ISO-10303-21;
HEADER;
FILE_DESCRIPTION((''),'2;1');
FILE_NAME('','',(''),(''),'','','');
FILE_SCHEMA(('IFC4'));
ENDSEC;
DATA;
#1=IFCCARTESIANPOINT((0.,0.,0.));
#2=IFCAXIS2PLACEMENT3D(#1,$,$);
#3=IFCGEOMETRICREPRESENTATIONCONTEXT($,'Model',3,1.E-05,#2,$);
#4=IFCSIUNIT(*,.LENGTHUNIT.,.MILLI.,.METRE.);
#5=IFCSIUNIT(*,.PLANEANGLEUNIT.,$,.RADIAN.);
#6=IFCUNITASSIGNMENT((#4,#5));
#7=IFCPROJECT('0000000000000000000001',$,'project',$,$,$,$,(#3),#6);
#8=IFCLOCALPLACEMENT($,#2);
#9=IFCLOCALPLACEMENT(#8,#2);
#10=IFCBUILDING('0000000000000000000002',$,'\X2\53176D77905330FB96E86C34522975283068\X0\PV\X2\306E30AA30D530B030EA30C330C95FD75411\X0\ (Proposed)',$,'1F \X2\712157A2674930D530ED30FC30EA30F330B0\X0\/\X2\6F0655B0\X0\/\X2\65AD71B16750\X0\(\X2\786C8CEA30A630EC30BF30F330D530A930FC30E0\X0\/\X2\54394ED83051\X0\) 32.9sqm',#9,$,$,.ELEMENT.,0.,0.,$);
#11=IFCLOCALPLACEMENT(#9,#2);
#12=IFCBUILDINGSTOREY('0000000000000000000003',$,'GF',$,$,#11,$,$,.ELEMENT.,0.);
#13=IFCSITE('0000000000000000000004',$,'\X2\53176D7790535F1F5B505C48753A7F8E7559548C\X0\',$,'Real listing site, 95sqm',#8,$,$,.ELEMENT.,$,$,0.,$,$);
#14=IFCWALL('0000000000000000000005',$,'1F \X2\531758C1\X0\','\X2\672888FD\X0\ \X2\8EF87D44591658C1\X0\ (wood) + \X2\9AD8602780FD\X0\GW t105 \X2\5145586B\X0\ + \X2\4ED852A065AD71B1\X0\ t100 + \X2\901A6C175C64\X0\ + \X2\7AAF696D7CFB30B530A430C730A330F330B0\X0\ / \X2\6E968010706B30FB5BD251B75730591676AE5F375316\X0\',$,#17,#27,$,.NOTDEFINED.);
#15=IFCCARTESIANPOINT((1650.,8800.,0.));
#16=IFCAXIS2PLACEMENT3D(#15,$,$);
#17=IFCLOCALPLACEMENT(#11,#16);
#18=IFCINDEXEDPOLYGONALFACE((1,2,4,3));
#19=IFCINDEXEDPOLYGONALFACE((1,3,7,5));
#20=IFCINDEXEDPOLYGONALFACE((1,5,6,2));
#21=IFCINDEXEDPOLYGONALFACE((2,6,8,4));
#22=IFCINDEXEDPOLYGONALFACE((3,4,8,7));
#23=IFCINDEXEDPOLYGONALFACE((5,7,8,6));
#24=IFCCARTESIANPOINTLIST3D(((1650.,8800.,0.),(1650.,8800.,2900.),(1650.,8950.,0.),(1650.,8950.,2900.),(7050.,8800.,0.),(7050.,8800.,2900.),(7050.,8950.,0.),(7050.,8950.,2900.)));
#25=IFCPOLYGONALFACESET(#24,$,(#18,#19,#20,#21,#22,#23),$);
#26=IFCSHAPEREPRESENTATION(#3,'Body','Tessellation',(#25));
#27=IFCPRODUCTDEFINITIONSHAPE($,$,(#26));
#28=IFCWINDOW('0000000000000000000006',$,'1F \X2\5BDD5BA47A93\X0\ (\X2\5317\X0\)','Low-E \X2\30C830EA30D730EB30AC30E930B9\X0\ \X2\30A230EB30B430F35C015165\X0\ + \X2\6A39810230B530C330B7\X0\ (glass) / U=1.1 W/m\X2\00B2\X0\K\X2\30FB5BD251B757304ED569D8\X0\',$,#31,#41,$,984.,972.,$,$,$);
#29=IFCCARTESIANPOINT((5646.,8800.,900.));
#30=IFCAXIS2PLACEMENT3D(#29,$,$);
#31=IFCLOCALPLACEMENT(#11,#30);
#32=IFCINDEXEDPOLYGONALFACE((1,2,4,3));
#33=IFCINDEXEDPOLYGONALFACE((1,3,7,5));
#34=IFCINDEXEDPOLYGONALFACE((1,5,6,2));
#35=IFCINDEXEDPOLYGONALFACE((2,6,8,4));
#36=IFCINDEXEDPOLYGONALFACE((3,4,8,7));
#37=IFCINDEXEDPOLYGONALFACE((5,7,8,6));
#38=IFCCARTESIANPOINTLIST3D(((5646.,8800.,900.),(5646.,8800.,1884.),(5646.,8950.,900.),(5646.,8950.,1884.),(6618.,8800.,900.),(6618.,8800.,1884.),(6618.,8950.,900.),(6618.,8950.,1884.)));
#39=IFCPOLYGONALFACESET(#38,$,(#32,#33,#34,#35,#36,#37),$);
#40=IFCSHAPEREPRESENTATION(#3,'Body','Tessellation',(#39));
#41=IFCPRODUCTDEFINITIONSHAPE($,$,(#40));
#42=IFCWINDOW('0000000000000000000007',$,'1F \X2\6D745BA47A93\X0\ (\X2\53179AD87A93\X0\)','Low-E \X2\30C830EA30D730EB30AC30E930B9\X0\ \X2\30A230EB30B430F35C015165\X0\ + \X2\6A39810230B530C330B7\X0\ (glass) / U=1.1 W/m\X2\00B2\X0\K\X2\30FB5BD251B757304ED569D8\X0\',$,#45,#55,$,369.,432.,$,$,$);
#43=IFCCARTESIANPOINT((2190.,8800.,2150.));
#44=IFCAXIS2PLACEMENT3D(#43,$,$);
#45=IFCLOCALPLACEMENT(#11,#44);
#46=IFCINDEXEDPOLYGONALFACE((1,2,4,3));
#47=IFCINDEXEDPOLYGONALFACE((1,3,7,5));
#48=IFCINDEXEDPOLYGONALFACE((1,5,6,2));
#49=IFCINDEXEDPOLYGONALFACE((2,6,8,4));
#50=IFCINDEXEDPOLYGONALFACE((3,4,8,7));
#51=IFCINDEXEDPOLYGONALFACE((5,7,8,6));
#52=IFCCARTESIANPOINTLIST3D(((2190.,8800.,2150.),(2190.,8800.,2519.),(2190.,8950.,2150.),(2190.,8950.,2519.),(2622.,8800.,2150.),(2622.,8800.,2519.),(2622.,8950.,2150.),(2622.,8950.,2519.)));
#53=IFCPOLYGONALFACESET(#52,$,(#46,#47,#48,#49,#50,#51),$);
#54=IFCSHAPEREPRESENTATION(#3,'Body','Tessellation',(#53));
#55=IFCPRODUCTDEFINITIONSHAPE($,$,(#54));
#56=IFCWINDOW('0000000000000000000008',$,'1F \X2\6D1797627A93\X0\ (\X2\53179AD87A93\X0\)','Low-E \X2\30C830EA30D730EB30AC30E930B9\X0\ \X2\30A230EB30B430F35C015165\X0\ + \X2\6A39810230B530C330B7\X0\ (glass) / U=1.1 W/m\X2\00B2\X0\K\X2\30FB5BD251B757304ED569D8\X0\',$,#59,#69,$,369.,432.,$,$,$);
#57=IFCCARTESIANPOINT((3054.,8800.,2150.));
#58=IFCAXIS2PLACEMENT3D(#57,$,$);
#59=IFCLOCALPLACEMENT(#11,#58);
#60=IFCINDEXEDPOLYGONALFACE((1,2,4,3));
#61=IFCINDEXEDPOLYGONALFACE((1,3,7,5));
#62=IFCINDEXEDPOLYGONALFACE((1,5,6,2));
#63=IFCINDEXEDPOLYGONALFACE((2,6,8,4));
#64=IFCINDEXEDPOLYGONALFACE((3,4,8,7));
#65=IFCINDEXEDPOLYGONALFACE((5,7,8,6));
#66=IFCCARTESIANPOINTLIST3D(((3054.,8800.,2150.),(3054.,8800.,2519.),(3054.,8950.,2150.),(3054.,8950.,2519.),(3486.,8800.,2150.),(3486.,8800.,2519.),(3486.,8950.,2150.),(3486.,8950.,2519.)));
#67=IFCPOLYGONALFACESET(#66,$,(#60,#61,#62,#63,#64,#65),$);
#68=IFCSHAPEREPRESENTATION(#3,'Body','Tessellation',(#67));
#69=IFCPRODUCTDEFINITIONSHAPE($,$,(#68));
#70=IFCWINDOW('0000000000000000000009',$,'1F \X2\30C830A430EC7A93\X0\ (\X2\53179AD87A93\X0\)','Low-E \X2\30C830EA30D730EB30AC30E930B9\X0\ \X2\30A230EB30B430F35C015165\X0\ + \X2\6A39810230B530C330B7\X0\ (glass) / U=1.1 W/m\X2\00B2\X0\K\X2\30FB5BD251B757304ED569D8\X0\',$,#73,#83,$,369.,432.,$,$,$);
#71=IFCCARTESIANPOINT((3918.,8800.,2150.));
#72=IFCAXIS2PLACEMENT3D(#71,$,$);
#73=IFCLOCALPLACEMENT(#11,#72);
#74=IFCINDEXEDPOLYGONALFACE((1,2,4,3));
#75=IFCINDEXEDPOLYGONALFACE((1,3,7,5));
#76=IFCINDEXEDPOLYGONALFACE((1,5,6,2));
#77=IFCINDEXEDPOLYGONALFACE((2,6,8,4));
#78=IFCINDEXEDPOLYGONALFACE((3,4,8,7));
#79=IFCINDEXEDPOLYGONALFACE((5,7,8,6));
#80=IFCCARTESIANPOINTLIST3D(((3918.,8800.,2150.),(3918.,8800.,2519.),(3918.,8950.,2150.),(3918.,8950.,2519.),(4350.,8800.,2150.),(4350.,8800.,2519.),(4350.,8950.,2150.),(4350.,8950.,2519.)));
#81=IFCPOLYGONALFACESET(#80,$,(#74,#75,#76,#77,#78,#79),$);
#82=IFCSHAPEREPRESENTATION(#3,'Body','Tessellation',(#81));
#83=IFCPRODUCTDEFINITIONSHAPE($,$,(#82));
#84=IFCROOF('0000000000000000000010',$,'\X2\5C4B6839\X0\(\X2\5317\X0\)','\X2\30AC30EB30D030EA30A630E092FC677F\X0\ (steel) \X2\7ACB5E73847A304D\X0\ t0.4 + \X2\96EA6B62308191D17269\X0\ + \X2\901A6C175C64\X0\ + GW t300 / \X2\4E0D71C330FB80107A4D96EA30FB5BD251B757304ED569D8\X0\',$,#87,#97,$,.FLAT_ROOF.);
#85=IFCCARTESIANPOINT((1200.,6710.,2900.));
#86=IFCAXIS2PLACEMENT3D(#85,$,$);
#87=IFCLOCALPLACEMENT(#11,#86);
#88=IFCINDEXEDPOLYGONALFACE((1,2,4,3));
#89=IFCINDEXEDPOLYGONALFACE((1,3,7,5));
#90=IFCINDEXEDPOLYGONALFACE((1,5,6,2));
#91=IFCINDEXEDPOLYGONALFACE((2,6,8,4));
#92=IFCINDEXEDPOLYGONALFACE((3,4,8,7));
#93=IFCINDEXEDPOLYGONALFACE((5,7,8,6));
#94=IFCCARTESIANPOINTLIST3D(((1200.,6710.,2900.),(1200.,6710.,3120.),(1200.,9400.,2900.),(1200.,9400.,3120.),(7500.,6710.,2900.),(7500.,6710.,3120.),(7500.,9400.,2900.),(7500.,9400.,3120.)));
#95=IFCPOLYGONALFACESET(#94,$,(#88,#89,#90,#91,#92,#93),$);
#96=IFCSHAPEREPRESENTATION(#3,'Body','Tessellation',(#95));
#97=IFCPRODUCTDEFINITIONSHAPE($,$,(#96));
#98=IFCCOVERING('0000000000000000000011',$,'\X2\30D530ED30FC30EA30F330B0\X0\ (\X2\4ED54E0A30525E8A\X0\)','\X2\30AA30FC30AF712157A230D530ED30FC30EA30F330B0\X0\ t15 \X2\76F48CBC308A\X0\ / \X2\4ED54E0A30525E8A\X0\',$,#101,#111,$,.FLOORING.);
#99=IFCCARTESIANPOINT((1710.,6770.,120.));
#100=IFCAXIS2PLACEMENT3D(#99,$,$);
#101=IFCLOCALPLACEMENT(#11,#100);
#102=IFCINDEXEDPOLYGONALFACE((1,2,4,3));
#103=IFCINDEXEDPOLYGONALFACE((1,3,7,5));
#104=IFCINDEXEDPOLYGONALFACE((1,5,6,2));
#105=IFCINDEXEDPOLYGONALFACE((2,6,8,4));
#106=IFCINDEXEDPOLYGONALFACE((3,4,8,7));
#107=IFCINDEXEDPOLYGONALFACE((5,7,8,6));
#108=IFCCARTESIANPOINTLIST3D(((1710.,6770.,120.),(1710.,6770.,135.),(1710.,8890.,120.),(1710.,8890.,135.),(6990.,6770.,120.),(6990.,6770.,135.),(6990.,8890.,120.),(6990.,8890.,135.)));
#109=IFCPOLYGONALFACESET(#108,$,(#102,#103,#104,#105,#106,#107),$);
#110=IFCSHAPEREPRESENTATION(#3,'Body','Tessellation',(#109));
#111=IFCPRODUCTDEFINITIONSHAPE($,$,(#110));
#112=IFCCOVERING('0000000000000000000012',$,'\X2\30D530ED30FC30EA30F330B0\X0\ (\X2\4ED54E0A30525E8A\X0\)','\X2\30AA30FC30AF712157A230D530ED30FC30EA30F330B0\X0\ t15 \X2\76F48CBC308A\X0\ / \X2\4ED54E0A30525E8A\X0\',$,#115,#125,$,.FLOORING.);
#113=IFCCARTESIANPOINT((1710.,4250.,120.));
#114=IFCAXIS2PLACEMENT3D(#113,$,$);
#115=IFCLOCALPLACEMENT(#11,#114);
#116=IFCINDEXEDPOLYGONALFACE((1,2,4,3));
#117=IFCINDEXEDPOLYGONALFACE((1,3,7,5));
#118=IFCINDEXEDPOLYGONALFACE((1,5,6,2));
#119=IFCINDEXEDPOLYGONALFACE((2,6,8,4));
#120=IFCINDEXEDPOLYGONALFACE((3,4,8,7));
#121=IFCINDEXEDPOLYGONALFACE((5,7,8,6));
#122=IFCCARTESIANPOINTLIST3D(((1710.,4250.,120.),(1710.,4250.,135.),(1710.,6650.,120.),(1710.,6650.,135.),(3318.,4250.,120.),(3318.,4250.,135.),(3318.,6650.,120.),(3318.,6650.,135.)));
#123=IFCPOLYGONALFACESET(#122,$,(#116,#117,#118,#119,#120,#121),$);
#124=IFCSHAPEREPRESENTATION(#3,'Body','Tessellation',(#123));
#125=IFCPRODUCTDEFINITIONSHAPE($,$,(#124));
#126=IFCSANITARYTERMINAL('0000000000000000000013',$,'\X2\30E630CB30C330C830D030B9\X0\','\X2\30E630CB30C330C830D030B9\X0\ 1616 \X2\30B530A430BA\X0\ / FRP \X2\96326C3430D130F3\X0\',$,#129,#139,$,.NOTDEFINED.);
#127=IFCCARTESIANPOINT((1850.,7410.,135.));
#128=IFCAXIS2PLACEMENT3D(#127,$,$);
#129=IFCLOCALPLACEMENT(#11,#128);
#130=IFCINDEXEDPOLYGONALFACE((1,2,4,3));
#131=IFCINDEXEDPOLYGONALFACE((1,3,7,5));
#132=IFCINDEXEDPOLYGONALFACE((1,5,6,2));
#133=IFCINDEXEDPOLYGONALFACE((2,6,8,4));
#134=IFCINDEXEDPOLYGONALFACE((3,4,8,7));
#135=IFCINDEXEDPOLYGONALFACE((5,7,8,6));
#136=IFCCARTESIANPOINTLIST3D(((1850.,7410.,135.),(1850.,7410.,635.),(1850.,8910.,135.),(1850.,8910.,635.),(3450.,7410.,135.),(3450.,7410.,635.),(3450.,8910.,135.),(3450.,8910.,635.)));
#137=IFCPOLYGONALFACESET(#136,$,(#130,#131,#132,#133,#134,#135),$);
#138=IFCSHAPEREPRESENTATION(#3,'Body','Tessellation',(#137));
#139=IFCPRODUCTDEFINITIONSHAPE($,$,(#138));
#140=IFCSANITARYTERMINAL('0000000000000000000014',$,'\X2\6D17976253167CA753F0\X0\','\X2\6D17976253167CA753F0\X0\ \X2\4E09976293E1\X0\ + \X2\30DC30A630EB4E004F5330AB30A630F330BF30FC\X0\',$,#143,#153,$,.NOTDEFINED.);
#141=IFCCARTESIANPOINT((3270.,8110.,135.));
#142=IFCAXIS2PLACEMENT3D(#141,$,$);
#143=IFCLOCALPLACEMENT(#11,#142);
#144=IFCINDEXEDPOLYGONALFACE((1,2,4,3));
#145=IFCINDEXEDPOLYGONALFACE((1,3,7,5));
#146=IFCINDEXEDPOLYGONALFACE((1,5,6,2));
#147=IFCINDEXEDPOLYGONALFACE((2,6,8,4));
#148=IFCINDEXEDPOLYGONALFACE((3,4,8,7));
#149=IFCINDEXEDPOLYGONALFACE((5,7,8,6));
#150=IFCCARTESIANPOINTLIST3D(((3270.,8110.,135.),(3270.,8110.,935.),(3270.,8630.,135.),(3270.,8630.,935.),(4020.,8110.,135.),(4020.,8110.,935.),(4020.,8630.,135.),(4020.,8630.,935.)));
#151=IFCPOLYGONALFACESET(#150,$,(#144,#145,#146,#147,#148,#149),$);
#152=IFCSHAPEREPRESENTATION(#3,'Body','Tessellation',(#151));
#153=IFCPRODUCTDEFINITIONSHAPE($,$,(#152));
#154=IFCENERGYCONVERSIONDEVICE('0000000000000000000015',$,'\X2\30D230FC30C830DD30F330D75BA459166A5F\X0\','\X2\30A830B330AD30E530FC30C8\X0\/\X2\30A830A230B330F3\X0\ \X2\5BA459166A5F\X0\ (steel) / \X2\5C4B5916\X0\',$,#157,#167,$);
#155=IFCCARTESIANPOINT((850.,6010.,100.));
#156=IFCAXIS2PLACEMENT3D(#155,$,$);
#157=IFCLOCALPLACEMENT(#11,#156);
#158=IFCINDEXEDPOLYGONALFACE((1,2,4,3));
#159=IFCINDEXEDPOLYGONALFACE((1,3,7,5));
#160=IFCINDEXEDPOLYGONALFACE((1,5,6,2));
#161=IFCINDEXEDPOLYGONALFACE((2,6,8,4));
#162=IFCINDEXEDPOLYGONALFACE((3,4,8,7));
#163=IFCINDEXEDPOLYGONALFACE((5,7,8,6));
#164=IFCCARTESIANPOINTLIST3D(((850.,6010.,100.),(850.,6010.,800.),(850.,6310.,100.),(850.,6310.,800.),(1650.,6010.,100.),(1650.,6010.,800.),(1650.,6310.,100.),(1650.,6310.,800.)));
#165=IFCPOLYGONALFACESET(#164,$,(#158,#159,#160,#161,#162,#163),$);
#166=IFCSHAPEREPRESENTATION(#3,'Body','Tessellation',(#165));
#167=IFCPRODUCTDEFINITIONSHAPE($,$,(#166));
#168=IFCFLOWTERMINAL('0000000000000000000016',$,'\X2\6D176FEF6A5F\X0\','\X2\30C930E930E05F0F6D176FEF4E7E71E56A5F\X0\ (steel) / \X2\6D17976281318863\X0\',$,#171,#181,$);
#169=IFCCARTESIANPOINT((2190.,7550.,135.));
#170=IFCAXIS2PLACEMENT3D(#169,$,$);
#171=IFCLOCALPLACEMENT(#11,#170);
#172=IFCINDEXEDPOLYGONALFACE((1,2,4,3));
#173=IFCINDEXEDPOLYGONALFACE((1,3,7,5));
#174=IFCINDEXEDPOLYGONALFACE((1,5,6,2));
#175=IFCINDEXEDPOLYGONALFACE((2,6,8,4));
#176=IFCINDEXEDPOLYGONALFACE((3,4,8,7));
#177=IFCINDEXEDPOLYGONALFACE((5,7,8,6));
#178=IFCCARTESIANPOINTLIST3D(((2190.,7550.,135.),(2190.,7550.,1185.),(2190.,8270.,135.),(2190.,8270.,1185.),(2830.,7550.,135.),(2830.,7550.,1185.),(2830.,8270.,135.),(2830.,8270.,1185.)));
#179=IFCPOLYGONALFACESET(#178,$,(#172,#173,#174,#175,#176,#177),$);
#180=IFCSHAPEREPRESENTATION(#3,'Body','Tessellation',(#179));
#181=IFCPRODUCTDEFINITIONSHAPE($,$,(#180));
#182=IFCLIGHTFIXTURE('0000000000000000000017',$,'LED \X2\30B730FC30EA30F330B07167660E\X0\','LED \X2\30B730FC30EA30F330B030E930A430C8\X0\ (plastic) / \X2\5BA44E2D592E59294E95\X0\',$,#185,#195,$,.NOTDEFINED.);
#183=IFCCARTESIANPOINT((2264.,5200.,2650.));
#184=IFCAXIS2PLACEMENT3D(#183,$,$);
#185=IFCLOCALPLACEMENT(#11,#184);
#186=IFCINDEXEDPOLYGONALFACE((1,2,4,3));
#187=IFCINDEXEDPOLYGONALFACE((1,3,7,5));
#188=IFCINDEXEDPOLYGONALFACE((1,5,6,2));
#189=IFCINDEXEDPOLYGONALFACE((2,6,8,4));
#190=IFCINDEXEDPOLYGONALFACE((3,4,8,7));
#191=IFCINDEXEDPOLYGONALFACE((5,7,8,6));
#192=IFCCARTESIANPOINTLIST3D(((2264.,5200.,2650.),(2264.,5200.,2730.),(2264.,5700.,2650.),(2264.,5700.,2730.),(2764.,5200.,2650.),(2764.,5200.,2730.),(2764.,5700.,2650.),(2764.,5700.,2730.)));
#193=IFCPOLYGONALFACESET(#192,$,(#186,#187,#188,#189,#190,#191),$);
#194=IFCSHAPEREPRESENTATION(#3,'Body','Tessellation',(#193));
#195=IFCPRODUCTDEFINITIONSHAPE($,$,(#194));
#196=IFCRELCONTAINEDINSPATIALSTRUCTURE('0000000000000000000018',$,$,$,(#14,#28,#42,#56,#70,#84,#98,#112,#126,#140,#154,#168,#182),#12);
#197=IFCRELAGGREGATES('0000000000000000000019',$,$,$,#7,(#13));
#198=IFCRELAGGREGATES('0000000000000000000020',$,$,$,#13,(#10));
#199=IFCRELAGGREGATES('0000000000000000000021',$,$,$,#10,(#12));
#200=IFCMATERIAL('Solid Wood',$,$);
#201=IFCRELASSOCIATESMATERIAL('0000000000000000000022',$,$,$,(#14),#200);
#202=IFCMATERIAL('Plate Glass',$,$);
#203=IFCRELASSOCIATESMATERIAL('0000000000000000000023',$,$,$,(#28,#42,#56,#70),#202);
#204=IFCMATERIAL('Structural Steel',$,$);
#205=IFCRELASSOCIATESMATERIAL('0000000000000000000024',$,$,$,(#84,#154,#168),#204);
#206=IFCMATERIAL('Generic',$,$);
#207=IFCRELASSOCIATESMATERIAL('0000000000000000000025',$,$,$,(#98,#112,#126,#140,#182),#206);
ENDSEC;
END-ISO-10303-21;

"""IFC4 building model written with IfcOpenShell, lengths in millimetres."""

from ifc_helpers import new_model, si_unit, frame, frame_2d, origin, place, context, project, spatial, rectangle, extrude, material, element, fill, save


model = new_model("IFC4")

# Units and contexts
model_context = context("Model", 3, precision=1e-05, world=origin())
ifc_project = project(units=[si_unit("LENGTHUNIT", "METRE", prefix="MILLI"), si_unit("PLANEANGLEUNIT", "RADIAN")], contexts=[model_context])

# Site, building, storey
site_placement = place(None, origin())
site = spatial("IfcSite", under=ifc_project, at=site_placement, Name="北海道弟子屈町美留和", ObjectType="Real listing site, 95sqm", CompositionType="ELEMENT", RefElevation=0.0)
building_placement = place(site_placement, origin())
building = spatial("IfcBuilding", under=site, at=building_placement, Name="北海道・雨水利用とPVのオフグリッド志向 (Proposed)", ObjectType="1F 無垢杉フローリング/漆喰/断熱材(硬質ウレタンフォーム/吹付け) 32.9sqm", CompositionType="ELEMENT", ElevationOfRefHeight=0.0, ElevationOfTerrain=0.0)
storey_placement = place(building_placement, origin())
storey = spatial("IfcBuildingStorey", under=building, at=storey_placement, Name="GF", CompositionType="ELEMENT", Elevation=0.0)

# Shared definitions
ifc_material_1 = material(Name="Solid Wood")

# Wall, openings, windows
wall_1_placement = place(storey_placement, frame((1650.0, 8800.0, 0.0)))
wall_1 = element("IfcWall", 1, at=wall_1_placement, inside=storey, material=ifc_material_1, Name="1F 北壁", Description="木製 軸組外壁 (wood) + 高性能GW t105 充填 + 付加断熱 t100 + 通気層 + 窯業系サイディング / 準耐火・寒冷地外皮強化", PredefinedType="NOTDEFINED", context=model_context, shape_type="SweptSolid", body=[
    extrude(rectangle(XDim=5400.0, YDim=150.0, at=frame_2d((2700.0, 75.0))), frame((1650.0, 8800.0, 0.0)), (0.0, 0.0, 1.0), 2900.0),
])
opening_1_placement = place(storey_placement, frame((5646.0, 8800.0, 900.0)))
opening_1 = element("IfcOpeningElement", 2, at=opening_1_placement, cuts=wall_1, PredefinedType="NOTDEFINED", context=model_context, shape_type="SweptSolid", body=[
    extrude(rectangle(XDim=972.0, YDim=150.0, at=frame_2d((486.0, 75.0))), frame((5646.0, 8800.0, 900.0)), (0.0, 0.0, 1.0), 984.0),
])
opening_2_placement = place(storey_placement, frame((2190.0, 8800.0, 2150.0)))
opening_2 = element("IfcOpeningElement", 3, at=opening_2_placement, cuts=wall_1, PredefinedType="NOTDEFINED", context=model_context, shape_type="SweptSolid", body=[
    extrude(rectangle(XDim=432.0, YDim=150.0, at=frame_2d((216.0, 75.0))), frame((2190.0, 8800.0, 2150.0)), (0.0, 0.0, 1.0), 369.0),
])
opening_3_placement = place(storey_placement, frame((3054.0, 8800.0, 2150.0)))
opening_3 = element("IfcOpeningElement", 4, at=opening_3_placement, cuts=wall_1, PredefinedType="NOTDEFINED", context=model_context, shape_type="SweptSolid", body=[
    extrude(rectangle(XDim=432.0, YDim=150.0, at=frame_2d((216.0, 75.0))), frame((3054.0, 8800.0, 2150.0)), (0.0, 0.0, 1.0), 369.0),
])
opening_4_placement = place(storey_placement, frame((3918.0, 8800.0, 2150.0)))
opening_4 = element("IfcOpeningElement", 5, at=opening_4_placement, cuts=wall_1, PredefinedType="NOTDEFINED", context=model_context, shape_type="SweptSolid", body=[
    extrude(rectangle(XDim=432.0, YDim=150.0, at=frame_2d((216.0, 75.0))), frame((3918.0, 8800.0, 2150.0)), (0.0, 0.0, 1.0), 369.0),
])
ifc_material_2 = material(Name="Plate Glass")
window_1_placement = place(storey_placement, frame((5646.0, 8800.0, 900.0)))
window_1 = element("IfcWindow", 6, at=window_1_placement, inside=storey, material=ifc_material_2, Name="1F 寝室窓 (北)", Description="Low-E トリプルガラス アルゴン封入 + 樹脂サッシ (glass) / U=1.1 W/m²K・寒冷地仕様", OverallHeight=984.0, OverallWidth=972.0, context=model_context, shape_type="SweptSolid", body=[
    extrude(rectangle(XDim=972.0, YDim=150.0, at=frame_2d((486.0, 75.0))), frame((5646.0, 8800.0, 900.0)), (0.0, 0.0, 1.0), 984.0),
])
fill(opening_1, window_1)
window_2_placement = place(storey_placement, frame((2190.0, 8800.0, 2150.0)))
window_2 = element("IfcWindow", 7, at=window_2_placement, inside=storey, material=ifc_material_2, Name="1F 浴室窓 (北高窓)", Description="Low-E トリプルガラス アルゴン封入 + 樹脂サッシ (glass) / U=1.1 W/m²K・寒冷地仕様", OverallHeight=369.0, OverallWidth=432.0, context=model_context, shape_type="SweptSolid", body=[
    extrude(rectangle(XDim=432.0, YDim=150.0, at=frame_2d((216.0, 75.0))), frame((2190.0, 8800.0, 2150.0)), (0.0, 0.0, 1.0), 369.0),
])
fill(opening_2, window_2)
window_3_placement = place(storey_placement, frame((3054.0, 8800.0, 2150.0)))
window_3 = element("IfcWindow", 8, at=window_3_placement, inside=storey, material=ifc_material_2, Name="1F 洗面窓 (北高窓)", Description="Low-E トリプルガラス アルゴン封入 + 樹脂サッシ (glass) / U=1.1 W/m²K・寒冷地仕様", OverallHeight=369.0, OverallWidth=432.0, context=model_context, shape_type="SweptSolid", body=[
    extrude(rectangle(XDim=432.0, YDim=150.0, at=frame_2d((216.0, 75.0))), frame((3054.0, 8800.0, 2150.0)), (0.0, 0.0, 1.0), 369.0),
])
fill(opening_3, window_3)
window_4_placement = place(storey_placement, frame((3918.0, 8800.0, 2150.0)))
window_4 = element("IfcWindow", 9, at=window_4_placement, inside=storey, material=ifc_material_2, Name="1F トイレ窓 (北高窓)", Description="Low-E トリプルガラス アルゴン封入 + 樹脂サッシ (glass) / U=1.1 W/m²K・寒冷地仕様", OverallHeight=369.0, OverallWidth=432.0, context=model_context, shape_type="SweptSolid", body=[
    extrude(rectangle(XDim=432.0, YDim=150.0, at=frame_2d((216.0, 75.0))), frame((3918.0, 8800.0, 2150.0)), (0.0, 0.0, 1.0), 369.0),
])
fill(opening_4, window_4)

# Roof
ifc_material_3 = material(Name="Structural Steel")
roof_placement = place(storey_placement, frame((1200.0, 6710.0, 2900.0)))
element("IfcRoof", 10, at=roof_placement, inside=storey, material=ifc_material_3, Name="屋根(北)", Description="ガルバリウム鋼板 (steel) 立平葺き t0.4 + 雪止め金物 + 通気層 + GW t300 / 不燃・耐積雪・寒冷地仕様", PredefinedType="FLAT_ROOF", context=model_context, shape_type="SweptSolid", body=[
    extrude(rectangle(XDim=6300.0, YDim=2690.0, at=frame_2d((3150.0, 1345.0))), frame((1200.0, 6710.0, 2900.0)), (0.0, 0.0, 1.0), 220.0),
])

# Coverings
ifc_material_4 = material(Name="Generic")
covering_1_placement = place(storey_placement, frame((1710.0, 6770.0, 120.0)))
element("IfcCovering", 11, at=covering_1_placement, inside=storey, material=ifc_material_4, Name="フローリング (仕上げ床)", Description="オーク無垢フローリング t15 直貼り / 仕上げ床", PredefinedType="FLOORING", context=model_context, shape_type="SweptSolid", body=[
    extrude(rectangle(XDim=5280.0, YDim=2120.0, at=frame_2d((2640.0, 1060.0))), frame((1710.0, 6770.0, 120.0)), (0.0, 0.0, 1.0), 15.0),
])
covering_2_placement = place(storey_placement, frame((1710.0, 4250.0, 120.0)))
element("IfcCovering", 12, at=covering_2_placement, inside=storey, material=ifc_material_4, Name="フローリング (仕上げ床)", Description="オーク無垢フローリング t15 直貼り / 仕上げ床", PredefinedType="FLOORING", context=model_context, shape_type="SweptSolid", body=[
    extrude(rectangle(XDim=1608.0, YDim=2400.0, at=frame_2d((804.0, 1200.0))), frame((1710.0, 4250.0, 120.0)), (0.0, 0.0, 1.0), 15.0),
])

# Sanitary terminals
sanitary_terminal_1_placement = place(storey_placement, frame((1850.0, 7410.0, 135.0)))
element("IfcSanitaryTerminal", 13, at=sanitary_terminal_1_placement, inside=storey, material=ifc_material_4, Name="ユニットバス", Description="ユニットバス 1616 サイズ / FRP 防水パン", PredefinedType="NOTDEFINED", context=model_context, shape_type="SweptSolid", body=[
    extrude(rectangle(XDim=1600.0, YDim=1500.0, at=frame_2d((800.0, 750.0))), frame((1850.0, 7410.0, 135.0)), (0.0, 0.0, 1.0), 500.0),
])
sanitary_terminal_2_placement = place(storey_placement, frame((3270.0, 8110.0, 135.0)))
element("IfcSanitaryTerminal", 14, at=sanitary_terminal_2_placement, inside=storey, material=ifc_material_4, Name="洗面化粧台", Description="洗面化粧台 三面鏡 + ボウル一体カウンター", PredefinedType="NOTDEFINED", context=model_context, shape_type="SweptSolid", body=[
    extrude(rectangle(XDim=750.0, YDim=520.0, at=frame_2d((375.0, 260.0))), frame((3270.0, 8110.0, 135.0)), (0.0, 0.0, 1.0), 800.0),
])

# Energy conversion device
energy_conversion_device_placement = place(storey_placement, frame((850.0, 6010.0, 100.0)))
element("IfcEnergyConversionDevice", 15, at=energy_conversion_device_placement, inside=storey, material=ifc_material_3, Name="ヒートポンプ室外機", Description="エコキュート/エアコン 室外機 (steel) / 屋外", context=model_context, shape_type="SweptSolid", body=[
    extrude(rectangle(XDim=800.0, YDim=300.0, at=frame_2d((400.0, 150.0))), frame((850.0, 6010.0, 100.0)), (0.0, 0.0, 1.0), 700.0),
])

# Flow terminal
flow_terminal_placement = place(storey_placement, frame((2190.0, 7550.0, 135.0)))
element("IfcFlowTerminal", 16, at=flow_terminal_placement, inside=storey, material=ifc_material_3, Name="洗濯機", Description="ドラム式洗濯乾燥機 (steel) / 洗面脱衣", context=model_context, shape_type="SweptSolid", body=[
    extrude(rectangle(XDim=640.0, YDim=720.0, at=frame_2d((320.0, 360.0))), frame((2190.0, 7550.0, 135.0)), (0.0, 0.0, 1.0), 1050.0),
])

# Light fixture
light_fixture_placement = place(storey_placement, frame((2264.0, 5200.0, 2650.0)))
element("IfcLightFixture", 17, at=light_fixture_placement, inside=storey, material=ifc_material_4, Name="LED シーリング照明", Description="LED シーリングライト (plastic) / 室中央天井", PredefinedType="NOTDEFINED", context=model_context, shape_type="SweptSolid", body=[
    extrude(rectangle(XDim=500.0, YDim=500.0, at=frame_2d((250.0, 250.0))), frame((2264.0, 5200.0, 2650.0)), (0.0, 0.0, 1.0), 80.0),
])

save(model, "model.ifc")
